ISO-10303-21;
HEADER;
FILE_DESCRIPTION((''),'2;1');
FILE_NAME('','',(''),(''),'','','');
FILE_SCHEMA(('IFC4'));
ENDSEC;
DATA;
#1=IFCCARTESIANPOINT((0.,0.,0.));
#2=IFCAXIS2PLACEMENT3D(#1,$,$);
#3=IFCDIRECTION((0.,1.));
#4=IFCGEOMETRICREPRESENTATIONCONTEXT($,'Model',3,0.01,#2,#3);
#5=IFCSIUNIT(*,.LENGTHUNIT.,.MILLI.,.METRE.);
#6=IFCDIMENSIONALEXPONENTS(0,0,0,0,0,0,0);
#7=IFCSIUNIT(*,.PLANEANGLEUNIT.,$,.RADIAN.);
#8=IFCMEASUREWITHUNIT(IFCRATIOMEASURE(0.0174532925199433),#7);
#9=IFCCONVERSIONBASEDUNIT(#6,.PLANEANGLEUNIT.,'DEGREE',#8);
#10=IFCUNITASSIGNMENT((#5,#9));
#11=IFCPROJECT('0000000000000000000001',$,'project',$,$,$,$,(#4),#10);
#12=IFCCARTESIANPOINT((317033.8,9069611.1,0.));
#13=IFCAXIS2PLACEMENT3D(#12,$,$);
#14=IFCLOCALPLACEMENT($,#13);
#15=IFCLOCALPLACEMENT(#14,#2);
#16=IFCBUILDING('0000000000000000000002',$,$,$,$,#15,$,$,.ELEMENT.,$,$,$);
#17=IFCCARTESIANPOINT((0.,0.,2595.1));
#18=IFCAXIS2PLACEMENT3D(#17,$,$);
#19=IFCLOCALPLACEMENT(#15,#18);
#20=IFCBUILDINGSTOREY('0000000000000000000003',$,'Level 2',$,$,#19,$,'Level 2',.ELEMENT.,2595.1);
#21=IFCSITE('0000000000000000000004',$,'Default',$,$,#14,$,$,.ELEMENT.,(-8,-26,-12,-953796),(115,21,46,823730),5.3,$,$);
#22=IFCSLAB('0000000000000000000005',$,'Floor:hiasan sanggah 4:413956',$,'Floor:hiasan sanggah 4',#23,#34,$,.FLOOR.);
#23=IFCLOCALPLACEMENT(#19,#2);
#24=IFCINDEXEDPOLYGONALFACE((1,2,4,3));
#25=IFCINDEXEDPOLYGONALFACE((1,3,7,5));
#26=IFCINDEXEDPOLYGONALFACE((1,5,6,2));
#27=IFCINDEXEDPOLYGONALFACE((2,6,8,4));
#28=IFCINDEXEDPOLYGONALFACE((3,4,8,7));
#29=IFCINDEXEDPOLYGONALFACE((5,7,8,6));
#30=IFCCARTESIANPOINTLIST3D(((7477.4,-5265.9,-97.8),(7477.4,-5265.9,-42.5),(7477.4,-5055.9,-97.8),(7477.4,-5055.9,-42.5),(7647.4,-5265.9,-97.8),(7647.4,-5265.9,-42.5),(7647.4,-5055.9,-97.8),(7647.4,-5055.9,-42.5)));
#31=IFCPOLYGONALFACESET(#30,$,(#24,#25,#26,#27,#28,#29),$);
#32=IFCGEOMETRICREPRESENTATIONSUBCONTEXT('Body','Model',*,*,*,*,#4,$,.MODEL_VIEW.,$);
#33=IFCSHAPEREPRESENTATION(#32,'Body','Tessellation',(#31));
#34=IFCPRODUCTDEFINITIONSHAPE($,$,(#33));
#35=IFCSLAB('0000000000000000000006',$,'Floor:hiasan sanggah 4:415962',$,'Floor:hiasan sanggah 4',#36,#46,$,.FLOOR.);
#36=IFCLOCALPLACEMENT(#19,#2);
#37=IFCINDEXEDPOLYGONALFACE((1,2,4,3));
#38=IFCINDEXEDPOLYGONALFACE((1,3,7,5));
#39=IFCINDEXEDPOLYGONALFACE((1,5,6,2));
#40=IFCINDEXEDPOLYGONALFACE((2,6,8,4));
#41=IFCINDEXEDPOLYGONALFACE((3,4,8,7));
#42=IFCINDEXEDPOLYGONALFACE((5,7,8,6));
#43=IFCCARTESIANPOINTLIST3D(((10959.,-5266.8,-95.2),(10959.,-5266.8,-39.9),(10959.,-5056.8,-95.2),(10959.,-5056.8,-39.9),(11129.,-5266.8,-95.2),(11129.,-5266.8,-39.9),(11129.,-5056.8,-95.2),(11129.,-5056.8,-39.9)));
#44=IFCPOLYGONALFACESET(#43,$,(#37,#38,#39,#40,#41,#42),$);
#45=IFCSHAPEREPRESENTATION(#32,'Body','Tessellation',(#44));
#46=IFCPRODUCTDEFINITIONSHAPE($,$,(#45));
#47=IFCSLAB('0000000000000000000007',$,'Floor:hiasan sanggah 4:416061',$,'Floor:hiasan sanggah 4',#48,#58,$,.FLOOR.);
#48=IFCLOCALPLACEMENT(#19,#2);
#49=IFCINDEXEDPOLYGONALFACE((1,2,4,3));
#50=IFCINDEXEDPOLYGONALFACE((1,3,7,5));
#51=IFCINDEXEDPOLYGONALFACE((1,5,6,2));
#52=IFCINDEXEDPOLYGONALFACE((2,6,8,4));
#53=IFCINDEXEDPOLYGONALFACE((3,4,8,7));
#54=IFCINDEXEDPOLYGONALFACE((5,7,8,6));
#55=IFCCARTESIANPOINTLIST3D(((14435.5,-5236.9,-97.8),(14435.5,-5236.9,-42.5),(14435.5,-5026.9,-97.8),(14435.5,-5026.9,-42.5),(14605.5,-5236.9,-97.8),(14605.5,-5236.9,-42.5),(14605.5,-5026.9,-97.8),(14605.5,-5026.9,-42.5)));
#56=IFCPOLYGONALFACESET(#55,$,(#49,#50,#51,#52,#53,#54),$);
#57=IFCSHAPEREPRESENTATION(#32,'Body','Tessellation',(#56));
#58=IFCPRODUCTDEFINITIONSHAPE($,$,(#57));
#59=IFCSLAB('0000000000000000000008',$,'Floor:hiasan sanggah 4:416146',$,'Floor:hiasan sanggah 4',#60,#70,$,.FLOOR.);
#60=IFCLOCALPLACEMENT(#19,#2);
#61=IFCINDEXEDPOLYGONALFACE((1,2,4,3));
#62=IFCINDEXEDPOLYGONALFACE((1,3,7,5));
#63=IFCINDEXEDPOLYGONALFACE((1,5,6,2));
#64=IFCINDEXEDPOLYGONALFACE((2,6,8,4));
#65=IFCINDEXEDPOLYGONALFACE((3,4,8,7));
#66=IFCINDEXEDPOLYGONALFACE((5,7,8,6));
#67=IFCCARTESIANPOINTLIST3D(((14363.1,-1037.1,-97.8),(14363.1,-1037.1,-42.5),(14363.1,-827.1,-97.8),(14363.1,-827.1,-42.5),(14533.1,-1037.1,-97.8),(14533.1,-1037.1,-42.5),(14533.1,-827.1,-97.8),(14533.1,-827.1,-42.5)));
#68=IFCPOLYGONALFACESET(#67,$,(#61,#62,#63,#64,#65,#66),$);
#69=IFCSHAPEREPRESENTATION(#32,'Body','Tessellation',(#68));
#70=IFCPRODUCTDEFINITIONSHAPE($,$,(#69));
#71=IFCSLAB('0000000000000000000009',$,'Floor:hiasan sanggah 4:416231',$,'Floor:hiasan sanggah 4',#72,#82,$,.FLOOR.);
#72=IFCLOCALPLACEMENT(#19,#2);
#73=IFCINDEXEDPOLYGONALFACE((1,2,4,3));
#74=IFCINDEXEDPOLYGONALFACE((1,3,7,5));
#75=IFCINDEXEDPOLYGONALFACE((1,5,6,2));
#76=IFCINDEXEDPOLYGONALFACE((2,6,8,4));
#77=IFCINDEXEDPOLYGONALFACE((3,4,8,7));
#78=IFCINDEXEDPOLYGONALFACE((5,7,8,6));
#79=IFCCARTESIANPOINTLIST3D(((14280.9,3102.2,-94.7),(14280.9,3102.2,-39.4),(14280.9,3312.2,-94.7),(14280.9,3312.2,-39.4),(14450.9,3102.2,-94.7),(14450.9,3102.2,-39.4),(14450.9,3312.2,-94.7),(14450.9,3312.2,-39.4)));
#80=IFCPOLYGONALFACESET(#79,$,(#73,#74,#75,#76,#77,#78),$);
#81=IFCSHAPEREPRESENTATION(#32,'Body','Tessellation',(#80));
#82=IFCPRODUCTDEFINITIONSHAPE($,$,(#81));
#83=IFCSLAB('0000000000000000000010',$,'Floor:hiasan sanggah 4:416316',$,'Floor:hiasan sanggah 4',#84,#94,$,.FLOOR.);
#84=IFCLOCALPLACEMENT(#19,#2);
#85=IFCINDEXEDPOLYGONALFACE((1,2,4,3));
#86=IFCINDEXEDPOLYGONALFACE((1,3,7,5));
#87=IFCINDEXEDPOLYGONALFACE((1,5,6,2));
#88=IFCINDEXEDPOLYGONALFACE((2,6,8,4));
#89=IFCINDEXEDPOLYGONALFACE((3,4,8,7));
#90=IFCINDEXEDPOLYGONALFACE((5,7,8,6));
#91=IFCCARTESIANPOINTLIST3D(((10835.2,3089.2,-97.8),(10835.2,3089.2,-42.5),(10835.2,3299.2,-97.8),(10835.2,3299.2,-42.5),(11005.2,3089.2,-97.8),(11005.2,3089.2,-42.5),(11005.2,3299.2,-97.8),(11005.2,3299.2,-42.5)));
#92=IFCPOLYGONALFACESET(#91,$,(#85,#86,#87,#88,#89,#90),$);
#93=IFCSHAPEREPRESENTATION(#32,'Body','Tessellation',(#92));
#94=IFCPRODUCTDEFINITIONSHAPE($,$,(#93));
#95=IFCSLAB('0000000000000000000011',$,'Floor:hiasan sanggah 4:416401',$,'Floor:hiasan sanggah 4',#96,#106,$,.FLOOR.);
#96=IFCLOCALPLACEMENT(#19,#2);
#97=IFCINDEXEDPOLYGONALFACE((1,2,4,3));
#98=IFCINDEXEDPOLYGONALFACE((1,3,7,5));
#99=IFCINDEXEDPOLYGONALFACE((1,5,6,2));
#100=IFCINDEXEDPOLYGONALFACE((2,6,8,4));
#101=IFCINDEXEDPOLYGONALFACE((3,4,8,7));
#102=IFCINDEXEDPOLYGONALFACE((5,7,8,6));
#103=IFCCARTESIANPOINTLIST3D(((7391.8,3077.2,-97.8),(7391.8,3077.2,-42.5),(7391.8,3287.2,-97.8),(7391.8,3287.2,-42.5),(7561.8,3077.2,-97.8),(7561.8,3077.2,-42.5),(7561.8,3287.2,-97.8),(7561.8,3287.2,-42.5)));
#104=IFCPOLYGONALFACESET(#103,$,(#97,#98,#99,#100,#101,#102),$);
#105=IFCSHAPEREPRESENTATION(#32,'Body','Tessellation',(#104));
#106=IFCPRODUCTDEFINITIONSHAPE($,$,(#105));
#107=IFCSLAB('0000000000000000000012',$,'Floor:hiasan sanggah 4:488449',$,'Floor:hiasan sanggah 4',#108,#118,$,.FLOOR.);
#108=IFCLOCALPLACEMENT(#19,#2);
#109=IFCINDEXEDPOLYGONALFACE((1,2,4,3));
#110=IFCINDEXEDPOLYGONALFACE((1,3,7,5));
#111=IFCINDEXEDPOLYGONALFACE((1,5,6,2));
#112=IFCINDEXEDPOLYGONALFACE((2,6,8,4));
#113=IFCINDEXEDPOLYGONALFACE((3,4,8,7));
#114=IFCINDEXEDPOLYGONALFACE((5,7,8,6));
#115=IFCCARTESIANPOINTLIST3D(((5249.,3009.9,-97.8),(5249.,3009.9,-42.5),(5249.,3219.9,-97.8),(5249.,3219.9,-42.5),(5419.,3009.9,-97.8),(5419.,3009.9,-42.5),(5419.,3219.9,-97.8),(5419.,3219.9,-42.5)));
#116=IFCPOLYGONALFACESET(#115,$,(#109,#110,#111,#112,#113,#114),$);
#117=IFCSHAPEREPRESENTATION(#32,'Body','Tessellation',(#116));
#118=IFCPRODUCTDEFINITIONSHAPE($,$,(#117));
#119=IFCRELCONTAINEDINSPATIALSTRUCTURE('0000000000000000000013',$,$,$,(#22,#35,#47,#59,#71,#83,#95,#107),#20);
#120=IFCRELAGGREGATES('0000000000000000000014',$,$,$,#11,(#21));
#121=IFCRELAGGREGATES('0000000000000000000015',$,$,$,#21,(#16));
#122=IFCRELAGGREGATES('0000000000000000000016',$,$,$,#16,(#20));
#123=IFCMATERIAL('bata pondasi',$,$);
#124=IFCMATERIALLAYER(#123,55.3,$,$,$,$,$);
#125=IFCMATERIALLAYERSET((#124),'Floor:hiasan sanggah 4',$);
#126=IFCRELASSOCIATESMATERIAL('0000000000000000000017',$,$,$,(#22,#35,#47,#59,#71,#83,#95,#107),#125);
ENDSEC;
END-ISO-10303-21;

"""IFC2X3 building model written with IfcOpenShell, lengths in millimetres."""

from ifc_helpers import new_model, entity, si_unit, converted_unit, direction, frame, frame_2d, origin, origin_2d_with_axis, place, context, subcontext, project, spatial, rectangle, extrude, material, layer, layer_set, layer_usage, element, save


model = new_model("IFC2X3")

# Units and contexts
model_context = context("Model", 3, precision=0.01, world=origin(), true_north=direction((0.0, 1.0)))
body_context = subcontext(model_context, "Body", "Model", "MODEL_VIEW")
ifc_project = project(units=[si_unit("LENGTHUNIT", "METRE", prefix="MILLI"), converted_unit("PLANEANGLEUNIT", "DEGREE", entity("IfcRatioMeasure", 0.0174532925199433), si_unit("PLANEANGLEUNIT", "RADIAN"), dimensions=[0, 0, 0, 0, 0, 0, 0])], contexts=[model_context])

# Site, building, storey
site_placement = place(None, frame((317033.8, 9069611.1, 0.0)))
site = spatial("IfcSite", under=ifc_project, at=site_placement, Name="Default", CompositionType="ELEMENT", RefLatitude=(-8, -26, -12, -953796), RefLongitude=(115, 21, 46, 823730), RefElevation=5.3)
building_placement = place(site_placement, origin())
building = spatial("IfcBuilding", under=site, at=building_placement, CompositionType="ELEMENT")
storey_placement = place(building_placement, frame((0.0, 0.0, 2595.1)))
storey = spatial("IfcBuildingStorey", under=building, at=storey_placement, Name="Level 2", LongName="Level 2", CompositionType="ELEMENT", Elevation=2595.1)

# Slabs
ifc_material = material(Name="bata pondasi")
ifc_layer = layer(ifc_material, 55.3)
ifc_layer_set = layer_set([ifc_layer], Name="Floor:hiasan sanggah 4")
ifc_layer_usage_1 = layer_usage(ifc_layer_set, "AXIS3", "POSITIVE", 0.0)
slab_1_placement = place(building_placement, frame((0.0, 0.0, 2595.1)))
element("IfcSlab", 1, at=slab_1_placement, inside=storey, material=ifc_layer_usage_1, Name="Floor:hiasan sanggah 4:413956", ObjectType="Floor:hiasan sanggah 4", PredefinedType="FLOOR", context=body_context, shape_type="SweptSolid", body=[
    extrude(rectangle(XDim=210.0, YDim=170.0, at=origin_2d_with_axis()), frame((7562.4, -5160.9, -42.5), z_axis=(0.0, 0.0, -1.0), x_axis=(0.0, 1.0, 0.0)), (0.0, 0.0, 1.0), 55.3),
])
ifc_layer_usage_2 = layer_usage(ifc_layer_set, "AXIS3", "POSITIVE", 0.0)
slab_2_placement = place(building_placement, frame((0.0, 0.0, 2595.1)))
element("IfcSlab", 2, at=slab_2_placement, inside=storey, material=ifc_layer_usage_2, Name="Floor:hiasan sanggah 4:415962", ObjectType="Floor:hiasan sanggah 4", PredefinedType="FLOOR", context=body_context, shape_type="SweptSolid", body=[
    extrude(rectangle(XDim=210.0, YDim=170.0, at=origin_2d_with_axis()), frame((11044.0, -5161.8, -39.9), z_axis=(0.0, 0.0, -1.0), x_axis=(0.0, 1.0, 0.0)), (0.0, 0.0, 1.0), 55.3),
])
ifc_layer_usage_3 = layer_usage(ifc_layer_set, "AXIS3", "POSITIVE", 0.0)
slab_3_placement = place(storey_placement, origin())
element("IfcSlab", 3, at=slab_3_placement, inside=storey, material=ifc_layer_usage_3, Name="Floor:hiasan sanggah 4:416061", ObjectType="Floor:hiasan sanggah 4", PredefinedType="FLOOR", context=body_context, shape_type="SweptSolid", body=[
    extrude(rectangle(XDim=210.0, YDim=170.0, at=frame_2d((0.0, 0.0), x_axis=(1.0, 0.0))), frame((14520.5, -5131.9, -42.5), z_axis=(0.0, 0.0, -1.0), x_axis=(0.0, 1.0, 0.0)), (0.0, 0.0, 1.0), 55.3),
])
ifc_layer_usage_4 = layer_usage(ifc_layer_set, "AXIS3", "POSITIVE", 0.0)
slab_4_placement = place(storey_placement, origin())
element("IfcSlab", 4, at=slab_4_placement, inside=storey, material=ifc_layer_usage_4, Name="Floor:hiasan sanggah 4:416146", ObjectType="Floor:hiasan sanggah 4", PredefinedType="FLOOR", context=body_context, shape_type="SweptSolid", body=[
    extrude(rectangle(XDim=210.0, YDim=170.0, at=origin_2d_with_axis()), frame((14448.1, -932.1, -42.5), z_axis=(0.0, 0.0, -1.0), x_axis=(0.0, 1.0, 0.0)), (0.0, 0.0, 1.0), 55.3),
])
ifc_layer_usage_5 = layer_usage(ifc_layer_set, "AXIS3", "POSITIVE", 0.0)
slab_5_placement = place(storey_placement, origin())
element("IfcSlab", 5, at=slab_5_placement, inside=storey, material=ifc_layer_usage_5, Name="Floor:hiasan sanggah 4:416231", ObjectType="Floor:hiasan sanggah 4", PredefinedType="FLOOR", context=body_context, shape_type="SweptSolid", body=[
    extrude(rectangle(XDim=210.0, YDim=170.0, at=frame_2d((0.0, 0.0), x_axis=(1.0, 0.0))), frame((14365.9, 3207.2, -39.4), z_axis=(0.0, 0.0, -1.0), x_axis=(0.0, 1.0, 0.0)), (0.0, 0.0, 1.0), 55.3),
])
ifc_layer_usage_6 = layer_usage(ifc_layer_set, "AXIS3", "POSITIVE", 0.0)
slab_6_placement = place(storey_placement, origin())
element("IfcSlab", 6, at=slab_6_placement, inside=storey, material=ifc_layer_usage_6, Name="Floor:hiasan sanggah 4:416316", ObjectType="Floor:hiasan sanggah 4", PredefinedType="FLOOR", context=body_context, shape_type="SweptSolid", body=[
    extrude(rectangle(XDim=210.0, YDim=170.0, at=origin_2d_with_axis()), frame((10920.2, 3194.2, -42.5), z_axis=(0.0, 0.0, -1.0), x_axis=(0.0, 1.0, 0.0)), (0.0, 0.0, 1.0), 55.3),
])
ifc_layer_usage_7 = layer_usage(ifc_layer_set, "AXIS3", "POSITIVE", 0.0)
slab_7_placement = place(storey_placement, origin())
element("IfcSlab", 7, at=slab_7_placement, inside=storey, material=ifc_layer_usage_7, Name="Floor:hiasan sanggah 4:416401", ObjectType="Floor:hiasan sanggah 4", PredefinedType="FLOOR", context=body_context, shape_type="SweptSolid", body=[
    extrude(rectangle(XDim=210.0, YDim=170.0, at=origin_2d_with_axis()), frame((7476.8, 3182.2, -42.5), z_axis=(0.0, 0.0, -1.0), x_axis=(0.0, 1.0, 0.0)), (0.0, 0.0, 1.0), 55.3),
])
ifc_layer_usage_8 = layer_usage(ifc_layer_set, "AXIS3", "POSITIVE", 0.0)
slab_8_placement = place(storey_placement, origin())
element("IfcSlab", 8, at=slab_8_placement, inside=storey, material=ifc_layer_usage_8, Name="Floor:hiasan sanggah 4:488449", ObjectType="Floor:hiasan sanggah 4", PredefinedType="FLOOR", context=body_context, shape_type="SweptSolid", body=[
    extrude(rectangle(XDim=210.0, YDim=170.0, at=origin_2d_with_axis()), frame((5334.0, 3114.9, -42.5), z_axis=(0.0, 0.0, -1.0), x_axis=(0.0, 1.0, 0.0)), (0.0, 0.0, 1.0), 55.3),
])

save(model, "model.ifc")
